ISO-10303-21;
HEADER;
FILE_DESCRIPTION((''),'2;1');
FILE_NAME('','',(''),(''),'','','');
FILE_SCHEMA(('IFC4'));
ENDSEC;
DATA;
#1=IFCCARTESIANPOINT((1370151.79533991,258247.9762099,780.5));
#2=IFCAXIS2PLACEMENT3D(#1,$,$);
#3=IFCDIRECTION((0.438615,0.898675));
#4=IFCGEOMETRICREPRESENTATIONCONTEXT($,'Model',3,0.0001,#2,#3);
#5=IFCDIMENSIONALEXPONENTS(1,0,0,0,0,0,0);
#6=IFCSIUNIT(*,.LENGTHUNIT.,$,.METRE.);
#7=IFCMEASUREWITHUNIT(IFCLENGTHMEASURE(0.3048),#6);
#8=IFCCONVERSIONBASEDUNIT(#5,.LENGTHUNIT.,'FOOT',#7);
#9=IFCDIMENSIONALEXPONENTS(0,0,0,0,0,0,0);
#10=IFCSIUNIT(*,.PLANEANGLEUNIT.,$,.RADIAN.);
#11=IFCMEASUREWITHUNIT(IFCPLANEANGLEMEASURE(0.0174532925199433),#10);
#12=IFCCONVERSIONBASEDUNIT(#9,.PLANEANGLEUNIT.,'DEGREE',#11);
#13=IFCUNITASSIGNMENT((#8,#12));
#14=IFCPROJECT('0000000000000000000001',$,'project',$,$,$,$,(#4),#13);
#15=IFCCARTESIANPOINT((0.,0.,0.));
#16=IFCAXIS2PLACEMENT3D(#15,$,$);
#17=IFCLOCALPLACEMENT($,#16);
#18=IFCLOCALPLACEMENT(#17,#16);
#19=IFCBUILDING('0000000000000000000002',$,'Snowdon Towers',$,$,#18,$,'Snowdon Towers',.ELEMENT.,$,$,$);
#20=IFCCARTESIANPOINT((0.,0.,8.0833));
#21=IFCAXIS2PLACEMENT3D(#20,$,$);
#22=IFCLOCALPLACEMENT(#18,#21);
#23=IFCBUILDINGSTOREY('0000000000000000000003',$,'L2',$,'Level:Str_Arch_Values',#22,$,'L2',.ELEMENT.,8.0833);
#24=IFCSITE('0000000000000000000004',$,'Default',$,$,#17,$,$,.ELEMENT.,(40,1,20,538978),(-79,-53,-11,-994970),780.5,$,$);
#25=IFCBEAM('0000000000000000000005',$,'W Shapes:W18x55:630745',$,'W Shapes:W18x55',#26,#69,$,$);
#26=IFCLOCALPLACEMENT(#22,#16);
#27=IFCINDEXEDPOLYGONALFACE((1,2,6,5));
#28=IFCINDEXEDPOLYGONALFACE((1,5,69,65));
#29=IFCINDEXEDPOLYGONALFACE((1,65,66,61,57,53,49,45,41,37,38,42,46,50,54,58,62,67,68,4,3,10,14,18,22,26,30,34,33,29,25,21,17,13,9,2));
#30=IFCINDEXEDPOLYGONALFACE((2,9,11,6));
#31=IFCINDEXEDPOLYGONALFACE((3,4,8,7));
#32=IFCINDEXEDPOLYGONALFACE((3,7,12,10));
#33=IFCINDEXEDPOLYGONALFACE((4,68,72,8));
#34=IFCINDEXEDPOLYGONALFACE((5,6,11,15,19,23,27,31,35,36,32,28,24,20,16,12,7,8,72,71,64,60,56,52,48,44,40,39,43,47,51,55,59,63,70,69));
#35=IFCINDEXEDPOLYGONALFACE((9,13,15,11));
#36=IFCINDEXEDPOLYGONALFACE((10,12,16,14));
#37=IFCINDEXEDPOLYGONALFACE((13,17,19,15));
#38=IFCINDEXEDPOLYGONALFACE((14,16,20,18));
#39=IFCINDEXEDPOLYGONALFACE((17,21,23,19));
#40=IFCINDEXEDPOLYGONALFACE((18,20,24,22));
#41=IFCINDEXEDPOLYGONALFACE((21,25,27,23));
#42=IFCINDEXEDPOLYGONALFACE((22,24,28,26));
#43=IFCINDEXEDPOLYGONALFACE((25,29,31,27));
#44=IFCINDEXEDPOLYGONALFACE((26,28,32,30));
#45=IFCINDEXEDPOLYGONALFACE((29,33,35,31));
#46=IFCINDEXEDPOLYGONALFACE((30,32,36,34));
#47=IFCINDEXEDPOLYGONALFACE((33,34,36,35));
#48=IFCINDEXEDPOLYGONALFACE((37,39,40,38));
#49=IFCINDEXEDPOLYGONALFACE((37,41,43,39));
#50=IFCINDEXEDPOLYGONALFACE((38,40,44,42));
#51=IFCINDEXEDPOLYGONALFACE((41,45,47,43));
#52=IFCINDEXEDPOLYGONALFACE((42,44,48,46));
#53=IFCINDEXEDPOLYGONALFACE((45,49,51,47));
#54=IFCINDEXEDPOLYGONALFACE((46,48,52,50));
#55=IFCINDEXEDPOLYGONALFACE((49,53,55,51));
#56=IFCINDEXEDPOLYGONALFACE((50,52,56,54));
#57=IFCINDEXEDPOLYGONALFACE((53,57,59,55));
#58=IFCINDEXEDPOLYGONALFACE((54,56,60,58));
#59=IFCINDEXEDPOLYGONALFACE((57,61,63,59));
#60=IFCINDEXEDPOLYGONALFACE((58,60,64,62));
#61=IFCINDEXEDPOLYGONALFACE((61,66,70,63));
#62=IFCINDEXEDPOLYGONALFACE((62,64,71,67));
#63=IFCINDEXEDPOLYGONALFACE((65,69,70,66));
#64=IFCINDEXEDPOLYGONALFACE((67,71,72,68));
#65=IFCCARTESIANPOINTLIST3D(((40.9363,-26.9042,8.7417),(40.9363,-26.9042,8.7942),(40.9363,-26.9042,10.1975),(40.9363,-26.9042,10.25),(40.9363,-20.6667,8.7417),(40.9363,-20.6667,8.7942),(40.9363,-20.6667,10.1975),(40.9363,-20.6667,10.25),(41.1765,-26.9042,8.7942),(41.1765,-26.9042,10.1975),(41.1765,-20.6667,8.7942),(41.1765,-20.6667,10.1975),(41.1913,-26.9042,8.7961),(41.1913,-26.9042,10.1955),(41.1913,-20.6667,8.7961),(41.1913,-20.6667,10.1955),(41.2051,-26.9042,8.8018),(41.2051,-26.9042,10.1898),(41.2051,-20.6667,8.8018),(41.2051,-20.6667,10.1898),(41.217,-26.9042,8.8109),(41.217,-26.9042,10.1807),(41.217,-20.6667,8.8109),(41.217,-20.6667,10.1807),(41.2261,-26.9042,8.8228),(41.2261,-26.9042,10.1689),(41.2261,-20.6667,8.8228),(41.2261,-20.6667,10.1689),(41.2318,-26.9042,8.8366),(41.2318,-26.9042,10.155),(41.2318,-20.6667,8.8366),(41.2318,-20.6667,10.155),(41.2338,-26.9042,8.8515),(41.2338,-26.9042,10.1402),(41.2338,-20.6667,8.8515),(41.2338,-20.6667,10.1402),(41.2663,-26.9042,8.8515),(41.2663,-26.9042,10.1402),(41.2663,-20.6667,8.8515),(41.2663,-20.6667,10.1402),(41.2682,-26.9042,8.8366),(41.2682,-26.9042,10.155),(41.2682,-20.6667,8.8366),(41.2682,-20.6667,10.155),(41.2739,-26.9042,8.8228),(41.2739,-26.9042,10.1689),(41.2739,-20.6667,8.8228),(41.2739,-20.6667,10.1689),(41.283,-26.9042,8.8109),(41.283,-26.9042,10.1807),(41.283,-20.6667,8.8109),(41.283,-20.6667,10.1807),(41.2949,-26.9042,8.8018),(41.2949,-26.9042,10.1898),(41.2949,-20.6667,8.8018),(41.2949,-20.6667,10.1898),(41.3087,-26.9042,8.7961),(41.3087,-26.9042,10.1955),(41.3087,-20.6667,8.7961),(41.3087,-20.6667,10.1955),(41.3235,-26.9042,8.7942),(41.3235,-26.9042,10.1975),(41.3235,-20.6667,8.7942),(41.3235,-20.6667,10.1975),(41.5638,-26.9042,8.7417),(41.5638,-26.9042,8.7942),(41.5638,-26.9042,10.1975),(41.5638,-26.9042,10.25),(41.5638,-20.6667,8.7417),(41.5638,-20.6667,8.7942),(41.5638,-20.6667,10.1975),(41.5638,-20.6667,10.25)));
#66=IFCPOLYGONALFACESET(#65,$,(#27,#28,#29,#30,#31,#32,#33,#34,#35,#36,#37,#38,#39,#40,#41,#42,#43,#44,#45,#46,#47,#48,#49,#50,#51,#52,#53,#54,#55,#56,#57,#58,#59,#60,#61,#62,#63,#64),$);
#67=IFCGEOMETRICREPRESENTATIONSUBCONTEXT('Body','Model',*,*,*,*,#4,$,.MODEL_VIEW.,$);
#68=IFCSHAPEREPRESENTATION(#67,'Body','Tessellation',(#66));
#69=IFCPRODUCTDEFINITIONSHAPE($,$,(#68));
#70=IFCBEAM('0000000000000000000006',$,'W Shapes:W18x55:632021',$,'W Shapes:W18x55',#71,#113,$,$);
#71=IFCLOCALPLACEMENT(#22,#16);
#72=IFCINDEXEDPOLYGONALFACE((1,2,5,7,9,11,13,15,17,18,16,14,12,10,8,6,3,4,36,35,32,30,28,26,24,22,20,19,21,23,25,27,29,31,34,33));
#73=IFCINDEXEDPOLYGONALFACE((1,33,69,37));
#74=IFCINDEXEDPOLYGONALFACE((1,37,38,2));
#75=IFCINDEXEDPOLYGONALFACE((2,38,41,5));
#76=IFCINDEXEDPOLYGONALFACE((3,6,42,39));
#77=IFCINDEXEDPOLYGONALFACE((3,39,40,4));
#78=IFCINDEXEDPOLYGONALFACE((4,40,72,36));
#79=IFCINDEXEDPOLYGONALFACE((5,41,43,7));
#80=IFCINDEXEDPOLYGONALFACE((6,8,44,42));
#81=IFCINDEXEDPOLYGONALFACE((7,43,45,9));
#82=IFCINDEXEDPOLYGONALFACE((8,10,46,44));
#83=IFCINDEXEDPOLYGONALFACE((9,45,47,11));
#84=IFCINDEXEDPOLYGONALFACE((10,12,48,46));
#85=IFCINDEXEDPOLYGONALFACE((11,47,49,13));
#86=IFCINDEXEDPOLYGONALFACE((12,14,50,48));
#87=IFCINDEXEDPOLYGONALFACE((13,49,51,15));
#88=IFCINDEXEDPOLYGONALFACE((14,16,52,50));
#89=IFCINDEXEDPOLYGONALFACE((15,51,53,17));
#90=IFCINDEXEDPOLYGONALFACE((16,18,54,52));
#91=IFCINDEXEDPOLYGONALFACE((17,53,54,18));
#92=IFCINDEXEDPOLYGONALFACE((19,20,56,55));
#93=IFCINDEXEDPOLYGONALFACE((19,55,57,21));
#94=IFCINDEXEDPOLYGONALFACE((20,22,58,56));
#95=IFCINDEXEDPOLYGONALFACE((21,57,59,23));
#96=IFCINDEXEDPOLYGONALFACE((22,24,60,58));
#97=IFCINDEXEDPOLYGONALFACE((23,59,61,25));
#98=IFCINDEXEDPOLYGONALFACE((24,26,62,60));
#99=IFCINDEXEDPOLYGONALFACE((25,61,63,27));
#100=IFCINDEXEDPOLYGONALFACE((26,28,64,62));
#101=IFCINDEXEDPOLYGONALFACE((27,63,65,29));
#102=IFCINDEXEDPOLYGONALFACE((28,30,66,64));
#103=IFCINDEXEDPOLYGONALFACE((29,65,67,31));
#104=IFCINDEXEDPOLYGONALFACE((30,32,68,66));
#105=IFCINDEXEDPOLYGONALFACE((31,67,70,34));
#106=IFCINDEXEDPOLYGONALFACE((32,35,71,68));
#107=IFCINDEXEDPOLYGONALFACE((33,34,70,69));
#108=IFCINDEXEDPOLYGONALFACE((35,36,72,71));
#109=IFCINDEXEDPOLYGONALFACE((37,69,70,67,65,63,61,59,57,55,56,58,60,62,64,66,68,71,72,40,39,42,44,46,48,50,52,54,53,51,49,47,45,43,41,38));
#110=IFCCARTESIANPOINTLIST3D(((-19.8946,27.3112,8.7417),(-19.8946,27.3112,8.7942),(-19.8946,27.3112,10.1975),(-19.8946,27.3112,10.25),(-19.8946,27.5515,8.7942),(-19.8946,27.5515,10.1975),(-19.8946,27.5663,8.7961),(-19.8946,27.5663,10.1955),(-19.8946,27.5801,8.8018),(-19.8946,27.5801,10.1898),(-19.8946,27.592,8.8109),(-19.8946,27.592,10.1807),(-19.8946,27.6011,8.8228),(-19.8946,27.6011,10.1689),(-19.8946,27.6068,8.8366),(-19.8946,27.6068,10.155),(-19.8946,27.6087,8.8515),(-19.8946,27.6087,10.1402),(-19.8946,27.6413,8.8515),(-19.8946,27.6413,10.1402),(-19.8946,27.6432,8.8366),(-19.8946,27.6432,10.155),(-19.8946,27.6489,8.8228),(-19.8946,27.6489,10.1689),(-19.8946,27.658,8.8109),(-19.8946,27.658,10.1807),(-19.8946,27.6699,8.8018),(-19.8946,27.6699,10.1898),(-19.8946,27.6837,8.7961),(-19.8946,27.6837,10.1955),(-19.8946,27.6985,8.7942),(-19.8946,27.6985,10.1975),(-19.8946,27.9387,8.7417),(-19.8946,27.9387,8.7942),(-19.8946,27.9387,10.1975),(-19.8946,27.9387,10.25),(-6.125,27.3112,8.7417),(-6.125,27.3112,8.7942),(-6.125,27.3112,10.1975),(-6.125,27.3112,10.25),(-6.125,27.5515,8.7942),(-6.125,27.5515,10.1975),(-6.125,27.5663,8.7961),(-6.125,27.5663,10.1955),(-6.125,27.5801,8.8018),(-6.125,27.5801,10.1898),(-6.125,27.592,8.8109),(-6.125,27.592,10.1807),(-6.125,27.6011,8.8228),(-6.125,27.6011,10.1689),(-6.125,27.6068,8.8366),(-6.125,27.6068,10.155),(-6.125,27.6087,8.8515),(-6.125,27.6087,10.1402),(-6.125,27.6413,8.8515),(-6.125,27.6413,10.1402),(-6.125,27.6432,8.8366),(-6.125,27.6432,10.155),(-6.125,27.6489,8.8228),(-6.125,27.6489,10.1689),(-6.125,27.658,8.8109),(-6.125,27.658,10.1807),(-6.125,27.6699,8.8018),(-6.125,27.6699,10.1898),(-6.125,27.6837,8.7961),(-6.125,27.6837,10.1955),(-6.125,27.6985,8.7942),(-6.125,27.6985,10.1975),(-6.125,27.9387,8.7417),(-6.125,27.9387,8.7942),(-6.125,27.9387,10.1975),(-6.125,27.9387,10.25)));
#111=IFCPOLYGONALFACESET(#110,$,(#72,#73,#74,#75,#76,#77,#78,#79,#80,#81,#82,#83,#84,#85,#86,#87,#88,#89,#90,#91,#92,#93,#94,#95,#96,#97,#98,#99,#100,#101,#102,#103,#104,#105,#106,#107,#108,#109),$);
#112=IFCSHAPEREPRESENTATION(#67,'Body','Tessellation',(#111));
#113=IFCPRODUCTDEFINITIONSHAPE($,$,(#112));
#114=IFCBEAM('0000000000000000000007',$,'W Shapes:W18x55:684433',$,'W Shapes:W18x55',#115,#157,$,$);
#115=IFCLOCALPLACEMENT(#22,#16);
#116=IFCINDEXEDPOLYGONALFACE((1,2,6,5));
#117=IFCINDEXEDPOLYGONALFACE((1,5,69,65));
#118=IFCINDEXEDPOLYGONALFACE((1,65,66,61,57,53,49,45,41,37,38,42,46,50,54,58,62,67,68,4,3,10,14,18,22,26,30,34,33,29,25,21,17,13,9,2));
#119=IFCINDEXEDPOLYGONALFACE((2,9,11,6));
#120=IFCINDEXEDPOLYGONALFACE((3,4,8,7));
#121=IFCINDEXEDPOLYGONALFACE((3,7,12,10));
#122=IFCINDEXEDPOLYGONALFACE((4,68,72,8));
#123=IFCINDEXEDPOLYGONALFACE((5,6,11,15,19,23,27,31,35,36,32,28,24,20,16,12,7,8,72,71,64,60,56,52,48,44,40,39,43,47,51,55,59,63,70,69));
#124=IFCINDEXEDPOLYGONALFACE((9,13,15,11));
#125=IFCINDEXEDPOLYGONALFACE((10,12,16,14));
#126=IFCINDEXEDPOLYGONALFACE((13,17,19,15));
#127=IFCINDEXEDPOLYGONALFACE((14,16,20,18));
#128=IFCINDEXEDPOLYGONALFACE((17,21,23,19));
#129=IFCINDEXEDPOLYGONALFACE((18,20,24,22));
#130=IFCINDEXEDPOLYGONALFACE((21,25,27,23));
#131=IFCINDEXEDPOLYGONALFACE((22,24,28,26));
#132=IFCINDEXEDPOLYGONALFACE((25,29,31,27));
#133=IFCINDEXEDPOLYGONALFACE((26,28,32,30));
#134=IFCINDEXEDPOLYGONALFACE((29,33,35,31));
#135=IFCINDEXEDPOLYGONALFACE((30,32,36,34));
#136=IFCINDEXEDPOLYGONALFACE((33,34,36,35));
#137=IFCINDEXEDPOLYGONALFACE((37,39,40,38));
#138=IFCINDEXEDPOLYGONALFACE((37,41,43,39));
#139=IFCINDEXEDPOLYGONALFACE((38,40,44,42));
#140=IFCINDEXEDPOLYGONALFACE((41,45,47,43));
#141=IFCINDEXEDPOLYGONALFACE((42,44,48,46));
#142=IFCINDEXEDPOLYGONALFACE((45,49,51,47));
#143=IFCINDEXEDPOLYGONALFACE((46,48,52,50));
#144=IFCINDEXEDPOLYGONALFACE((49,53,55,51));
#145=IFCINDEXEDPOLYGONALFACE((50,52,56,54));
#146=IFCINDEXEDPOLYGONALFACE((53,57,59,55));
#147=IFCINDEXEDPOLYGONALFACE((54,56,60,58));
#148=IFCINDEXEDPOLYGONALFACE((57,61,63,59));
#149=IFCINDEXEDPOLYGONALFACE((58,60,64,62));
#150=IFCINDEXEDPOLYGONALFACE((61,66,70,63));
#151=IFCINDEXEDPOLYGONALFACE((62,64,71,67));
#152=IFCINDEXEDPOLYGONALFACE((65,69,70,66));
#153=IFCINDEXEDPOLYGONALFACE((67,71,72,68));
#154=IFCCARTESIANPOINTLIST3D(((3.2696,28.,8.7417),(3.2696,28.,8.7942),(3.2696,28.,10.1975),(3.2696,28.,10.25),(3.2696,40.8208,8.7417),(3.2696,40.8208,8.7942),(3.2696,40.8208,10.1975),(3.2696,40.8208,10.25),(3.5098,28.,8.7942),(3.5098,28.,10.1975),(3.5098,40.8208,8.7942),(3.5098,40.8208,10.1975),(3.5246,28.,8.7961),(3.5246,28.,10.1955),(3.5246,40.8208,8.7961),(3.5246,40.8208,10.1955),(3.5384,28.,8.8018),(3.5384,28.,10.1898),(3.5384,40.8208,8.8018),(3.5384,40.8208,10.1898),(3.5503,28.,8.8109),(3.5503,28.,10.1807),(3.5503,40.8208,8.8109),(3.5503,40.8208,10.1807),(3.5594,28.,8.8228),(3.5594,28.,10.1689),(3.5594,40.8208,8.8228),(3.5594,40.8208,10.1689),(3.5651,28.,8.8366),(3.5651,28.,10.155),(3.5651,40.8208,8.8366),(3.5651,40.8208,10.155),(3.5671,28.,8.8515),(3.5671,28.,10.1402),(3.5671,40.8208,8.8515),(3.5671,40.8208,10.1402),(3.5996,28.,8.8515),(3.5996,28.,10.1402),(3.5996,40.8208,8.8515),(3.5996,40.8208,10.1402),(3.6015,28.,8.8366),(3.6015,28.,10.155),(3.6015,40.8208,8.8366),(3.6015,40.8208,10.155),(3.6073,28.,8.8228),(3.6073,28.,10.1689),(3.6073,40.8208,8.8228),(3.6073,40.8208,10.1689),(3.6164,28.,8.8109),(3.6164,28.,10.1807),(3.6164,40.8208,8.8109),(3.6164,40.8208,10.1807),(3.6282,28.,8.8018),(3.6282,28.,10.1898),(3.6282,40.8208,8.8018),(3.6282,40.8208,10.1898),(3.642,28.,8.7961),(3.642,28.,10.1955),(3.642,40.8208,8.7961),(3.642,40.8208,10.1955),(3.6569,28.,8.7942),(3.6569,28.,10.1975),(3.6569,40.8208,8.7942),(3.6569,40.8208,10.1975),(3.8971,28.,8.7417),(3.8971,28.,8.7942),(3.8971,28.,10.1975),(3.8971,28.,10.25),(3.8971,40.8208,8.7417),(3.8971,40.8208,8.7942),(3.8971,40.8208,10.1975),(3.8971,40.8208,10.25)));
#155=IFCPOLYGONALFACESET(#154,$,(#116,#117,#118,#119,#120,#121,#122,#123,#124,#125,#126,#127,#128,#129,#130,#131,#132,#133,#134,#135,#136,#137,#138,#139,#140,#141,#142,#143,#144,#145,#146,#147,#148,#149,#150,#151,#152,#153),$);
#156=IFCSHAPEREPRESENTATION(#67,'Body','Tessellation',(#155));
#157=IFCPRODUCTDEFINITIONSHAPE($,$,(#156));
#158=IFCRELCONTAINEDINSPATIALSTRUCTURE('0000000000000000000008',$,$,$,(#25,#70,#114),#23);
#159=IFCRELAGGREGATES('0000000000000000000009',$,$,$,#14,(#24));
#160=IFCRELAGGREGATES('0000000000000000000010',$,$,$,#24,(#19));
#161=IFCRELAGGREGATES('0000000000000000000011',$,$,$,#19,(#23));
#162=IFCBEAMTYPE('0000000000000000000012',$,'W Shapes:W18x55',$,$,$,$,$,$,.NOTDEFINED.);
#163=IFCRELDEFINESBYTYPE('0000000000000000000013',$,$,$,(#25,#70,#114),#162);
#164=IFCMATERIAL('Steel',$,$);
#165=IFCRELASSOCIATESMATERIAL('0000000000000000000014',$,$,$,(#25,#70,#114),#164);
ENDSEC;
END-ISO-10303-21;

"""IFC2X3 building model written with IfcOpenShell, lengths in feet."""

from ifc_helpers import new_model, entity, si_unit, converted_unit, direction, frame, frame_2d, origin, place, context, subcontext, project, spatial, i_section, extrude, material, type_object, element, save


model = new_model("IFC2X3")

# Units and contexts
model_context = context("Model", 3, precision=0.0001, world=frame((1370151.79533991, 258247.9762099, 780.5)), true_north=direction((0.438615, 0.898675)))
body_context = subcontext(model_context, "Body", "Model", "MODEL_VIEW")
ifc_project = project(units=[converted_unit("LENGTHUNIT", "FOOT", entity("IfcLengthMeasure", 0.3048), si_unit("LENGTHUNIT", "METRE"), dimensions=[1, 0, 0, 0, 0, 0, 0]), converted_unit("PLANEANGLEUNIT", "DEGREE", entity("IfcPlaneAngleMeasure", 0.0174532925199433), si_unit("PLANEANGLEUNIT", "RADIAN"), dimensions=[0, 0, 0, 0, 0, 0, 0])], contexts=[model_context])

# Site, building, storey
site_placement = place(None, origin())
site = spatial("IfcSite", under=ifc_project, at=site_placement, Name="Default", CompositionType="ELEMENT", RefLatitude=(40, 1, 20, 538978), RefLongitude=(-79, -53, -11, -994970), RefElevation=780.5)
building_placement = place(site_placement, origin())
building = spatial("IfcBuilding", under=site, at=building_placement, Name="Snowdon Towers", LongName="Snowdon Towers", CompositionType="ELEMENT")
storey_placement = place(building_placement, frame((0.0, 0.0, 8.0833)))
storey = spatial("IfcBuildingStorey", under=building, at=storey_placement, Name="L2", ObjectType="Level:Str_Arch_Values", LongName="L2", CompositionType="ELEMENT", Elevation=8.0833)

# Beams
ifc_material = material(Name="Steel")
beam_type_1 = type_object("IfcBeamType", Name="W Shapes:W18x55", PredefinedType="NOTDEFINED")
beam_1_placement = place(storey_placement, frame((41.25, -20.125, 10.25), z_axis=(0.0, 0.0, 1.0), x_axis=(0.0, -1.0, 0.0)))
element("IfcBeam", 1, at=beam_1_placement, inside=storey, type_object=beam_type_1, material=ifc_material, Name="W Shapes:W18x55:630745", ObjectType="W Shapes:W18x55", context=body_context, shape_type="SweptSolid", body=[
    extrude(i_section(OverallWidth=0.6275, OverallDepth=1.5083, WebThickness=0.0325, FlangeThickness=0.0525, FilletRadius=0.0573, at=frame_2d((0.0, 0.0), x_axis=(0.0, 1.0))), frame((0.5417, 0.0, -0.7542), z_axis=(1.0, 0.0, 0.0), x_axis=(0.0, 0.0, -1.0)), (0.0, 0.0, 1.0), 6.2375),
])
beam_2_placement = place(storey_placement, frame((-5.6667, 27.625, 10.25), z_axis=(0.0, 0.0, 1.0), x_axis=(-1.0, 0.0, 0.0)))
element("IfcBeam", 2, at=beam_2_placement, inside=storey, type_object=beam_type_1, material=ifc_material, Name="W Shapes:W18x55:632021", ObjectType="W Shapes:W18x55", context=body_context, shape_type="SweptSolid", body=[
    extrude(i_section(OverallWidth=0.6275, OverallDepth=1.5083, WebThickness=0.0325, FlangeThickness=0.0525, FilletRadius=0.0573, at=frame_2d((0.0, 0.0), x_axis=(0.0, 1.0))), frame((0.4583, 0.0, -0.7542), z_axis=(1.0, 0.0, 0.0), x_axis=(0.0, 0.0, -1.0)), (0.0, 0.0, 1.0), 13.7696),
])
beam_3_placement = place(storey_placement, frame((3.5833, 41.625, 10.25), z_axis=(0.0, 0.0, 1.0), x_axis=(0.0, -1.0, 0.0)))
element("IfcBeam", 3, at=beam_3_placement, inside=storey, type_object=beam_type_1, material=ifc_material, Name="W Shapes:W18x55:684433", ObjectType="W Shapes:W18x55", context=body_context, shape_type="SweptSolid", body=[
    extrude(i_section(OverallWidth=0.6275, OverallDepth=1.5083, WebThickness=0.0325, FlangeThickness=0.0525, FilletRadius=0.0573, at=frame_2d((0.0, 0.0), x_axis=(0.0, 1.0))), frame((0.8042, 0.0, -0.7542), z_axis=(1.0, 0.0, 0.0), x_axis=(0.0, 0.0, -1.0)), (0.0, 0.0, 1.0), 12.8208),
])

save(model, "model.ifc")
